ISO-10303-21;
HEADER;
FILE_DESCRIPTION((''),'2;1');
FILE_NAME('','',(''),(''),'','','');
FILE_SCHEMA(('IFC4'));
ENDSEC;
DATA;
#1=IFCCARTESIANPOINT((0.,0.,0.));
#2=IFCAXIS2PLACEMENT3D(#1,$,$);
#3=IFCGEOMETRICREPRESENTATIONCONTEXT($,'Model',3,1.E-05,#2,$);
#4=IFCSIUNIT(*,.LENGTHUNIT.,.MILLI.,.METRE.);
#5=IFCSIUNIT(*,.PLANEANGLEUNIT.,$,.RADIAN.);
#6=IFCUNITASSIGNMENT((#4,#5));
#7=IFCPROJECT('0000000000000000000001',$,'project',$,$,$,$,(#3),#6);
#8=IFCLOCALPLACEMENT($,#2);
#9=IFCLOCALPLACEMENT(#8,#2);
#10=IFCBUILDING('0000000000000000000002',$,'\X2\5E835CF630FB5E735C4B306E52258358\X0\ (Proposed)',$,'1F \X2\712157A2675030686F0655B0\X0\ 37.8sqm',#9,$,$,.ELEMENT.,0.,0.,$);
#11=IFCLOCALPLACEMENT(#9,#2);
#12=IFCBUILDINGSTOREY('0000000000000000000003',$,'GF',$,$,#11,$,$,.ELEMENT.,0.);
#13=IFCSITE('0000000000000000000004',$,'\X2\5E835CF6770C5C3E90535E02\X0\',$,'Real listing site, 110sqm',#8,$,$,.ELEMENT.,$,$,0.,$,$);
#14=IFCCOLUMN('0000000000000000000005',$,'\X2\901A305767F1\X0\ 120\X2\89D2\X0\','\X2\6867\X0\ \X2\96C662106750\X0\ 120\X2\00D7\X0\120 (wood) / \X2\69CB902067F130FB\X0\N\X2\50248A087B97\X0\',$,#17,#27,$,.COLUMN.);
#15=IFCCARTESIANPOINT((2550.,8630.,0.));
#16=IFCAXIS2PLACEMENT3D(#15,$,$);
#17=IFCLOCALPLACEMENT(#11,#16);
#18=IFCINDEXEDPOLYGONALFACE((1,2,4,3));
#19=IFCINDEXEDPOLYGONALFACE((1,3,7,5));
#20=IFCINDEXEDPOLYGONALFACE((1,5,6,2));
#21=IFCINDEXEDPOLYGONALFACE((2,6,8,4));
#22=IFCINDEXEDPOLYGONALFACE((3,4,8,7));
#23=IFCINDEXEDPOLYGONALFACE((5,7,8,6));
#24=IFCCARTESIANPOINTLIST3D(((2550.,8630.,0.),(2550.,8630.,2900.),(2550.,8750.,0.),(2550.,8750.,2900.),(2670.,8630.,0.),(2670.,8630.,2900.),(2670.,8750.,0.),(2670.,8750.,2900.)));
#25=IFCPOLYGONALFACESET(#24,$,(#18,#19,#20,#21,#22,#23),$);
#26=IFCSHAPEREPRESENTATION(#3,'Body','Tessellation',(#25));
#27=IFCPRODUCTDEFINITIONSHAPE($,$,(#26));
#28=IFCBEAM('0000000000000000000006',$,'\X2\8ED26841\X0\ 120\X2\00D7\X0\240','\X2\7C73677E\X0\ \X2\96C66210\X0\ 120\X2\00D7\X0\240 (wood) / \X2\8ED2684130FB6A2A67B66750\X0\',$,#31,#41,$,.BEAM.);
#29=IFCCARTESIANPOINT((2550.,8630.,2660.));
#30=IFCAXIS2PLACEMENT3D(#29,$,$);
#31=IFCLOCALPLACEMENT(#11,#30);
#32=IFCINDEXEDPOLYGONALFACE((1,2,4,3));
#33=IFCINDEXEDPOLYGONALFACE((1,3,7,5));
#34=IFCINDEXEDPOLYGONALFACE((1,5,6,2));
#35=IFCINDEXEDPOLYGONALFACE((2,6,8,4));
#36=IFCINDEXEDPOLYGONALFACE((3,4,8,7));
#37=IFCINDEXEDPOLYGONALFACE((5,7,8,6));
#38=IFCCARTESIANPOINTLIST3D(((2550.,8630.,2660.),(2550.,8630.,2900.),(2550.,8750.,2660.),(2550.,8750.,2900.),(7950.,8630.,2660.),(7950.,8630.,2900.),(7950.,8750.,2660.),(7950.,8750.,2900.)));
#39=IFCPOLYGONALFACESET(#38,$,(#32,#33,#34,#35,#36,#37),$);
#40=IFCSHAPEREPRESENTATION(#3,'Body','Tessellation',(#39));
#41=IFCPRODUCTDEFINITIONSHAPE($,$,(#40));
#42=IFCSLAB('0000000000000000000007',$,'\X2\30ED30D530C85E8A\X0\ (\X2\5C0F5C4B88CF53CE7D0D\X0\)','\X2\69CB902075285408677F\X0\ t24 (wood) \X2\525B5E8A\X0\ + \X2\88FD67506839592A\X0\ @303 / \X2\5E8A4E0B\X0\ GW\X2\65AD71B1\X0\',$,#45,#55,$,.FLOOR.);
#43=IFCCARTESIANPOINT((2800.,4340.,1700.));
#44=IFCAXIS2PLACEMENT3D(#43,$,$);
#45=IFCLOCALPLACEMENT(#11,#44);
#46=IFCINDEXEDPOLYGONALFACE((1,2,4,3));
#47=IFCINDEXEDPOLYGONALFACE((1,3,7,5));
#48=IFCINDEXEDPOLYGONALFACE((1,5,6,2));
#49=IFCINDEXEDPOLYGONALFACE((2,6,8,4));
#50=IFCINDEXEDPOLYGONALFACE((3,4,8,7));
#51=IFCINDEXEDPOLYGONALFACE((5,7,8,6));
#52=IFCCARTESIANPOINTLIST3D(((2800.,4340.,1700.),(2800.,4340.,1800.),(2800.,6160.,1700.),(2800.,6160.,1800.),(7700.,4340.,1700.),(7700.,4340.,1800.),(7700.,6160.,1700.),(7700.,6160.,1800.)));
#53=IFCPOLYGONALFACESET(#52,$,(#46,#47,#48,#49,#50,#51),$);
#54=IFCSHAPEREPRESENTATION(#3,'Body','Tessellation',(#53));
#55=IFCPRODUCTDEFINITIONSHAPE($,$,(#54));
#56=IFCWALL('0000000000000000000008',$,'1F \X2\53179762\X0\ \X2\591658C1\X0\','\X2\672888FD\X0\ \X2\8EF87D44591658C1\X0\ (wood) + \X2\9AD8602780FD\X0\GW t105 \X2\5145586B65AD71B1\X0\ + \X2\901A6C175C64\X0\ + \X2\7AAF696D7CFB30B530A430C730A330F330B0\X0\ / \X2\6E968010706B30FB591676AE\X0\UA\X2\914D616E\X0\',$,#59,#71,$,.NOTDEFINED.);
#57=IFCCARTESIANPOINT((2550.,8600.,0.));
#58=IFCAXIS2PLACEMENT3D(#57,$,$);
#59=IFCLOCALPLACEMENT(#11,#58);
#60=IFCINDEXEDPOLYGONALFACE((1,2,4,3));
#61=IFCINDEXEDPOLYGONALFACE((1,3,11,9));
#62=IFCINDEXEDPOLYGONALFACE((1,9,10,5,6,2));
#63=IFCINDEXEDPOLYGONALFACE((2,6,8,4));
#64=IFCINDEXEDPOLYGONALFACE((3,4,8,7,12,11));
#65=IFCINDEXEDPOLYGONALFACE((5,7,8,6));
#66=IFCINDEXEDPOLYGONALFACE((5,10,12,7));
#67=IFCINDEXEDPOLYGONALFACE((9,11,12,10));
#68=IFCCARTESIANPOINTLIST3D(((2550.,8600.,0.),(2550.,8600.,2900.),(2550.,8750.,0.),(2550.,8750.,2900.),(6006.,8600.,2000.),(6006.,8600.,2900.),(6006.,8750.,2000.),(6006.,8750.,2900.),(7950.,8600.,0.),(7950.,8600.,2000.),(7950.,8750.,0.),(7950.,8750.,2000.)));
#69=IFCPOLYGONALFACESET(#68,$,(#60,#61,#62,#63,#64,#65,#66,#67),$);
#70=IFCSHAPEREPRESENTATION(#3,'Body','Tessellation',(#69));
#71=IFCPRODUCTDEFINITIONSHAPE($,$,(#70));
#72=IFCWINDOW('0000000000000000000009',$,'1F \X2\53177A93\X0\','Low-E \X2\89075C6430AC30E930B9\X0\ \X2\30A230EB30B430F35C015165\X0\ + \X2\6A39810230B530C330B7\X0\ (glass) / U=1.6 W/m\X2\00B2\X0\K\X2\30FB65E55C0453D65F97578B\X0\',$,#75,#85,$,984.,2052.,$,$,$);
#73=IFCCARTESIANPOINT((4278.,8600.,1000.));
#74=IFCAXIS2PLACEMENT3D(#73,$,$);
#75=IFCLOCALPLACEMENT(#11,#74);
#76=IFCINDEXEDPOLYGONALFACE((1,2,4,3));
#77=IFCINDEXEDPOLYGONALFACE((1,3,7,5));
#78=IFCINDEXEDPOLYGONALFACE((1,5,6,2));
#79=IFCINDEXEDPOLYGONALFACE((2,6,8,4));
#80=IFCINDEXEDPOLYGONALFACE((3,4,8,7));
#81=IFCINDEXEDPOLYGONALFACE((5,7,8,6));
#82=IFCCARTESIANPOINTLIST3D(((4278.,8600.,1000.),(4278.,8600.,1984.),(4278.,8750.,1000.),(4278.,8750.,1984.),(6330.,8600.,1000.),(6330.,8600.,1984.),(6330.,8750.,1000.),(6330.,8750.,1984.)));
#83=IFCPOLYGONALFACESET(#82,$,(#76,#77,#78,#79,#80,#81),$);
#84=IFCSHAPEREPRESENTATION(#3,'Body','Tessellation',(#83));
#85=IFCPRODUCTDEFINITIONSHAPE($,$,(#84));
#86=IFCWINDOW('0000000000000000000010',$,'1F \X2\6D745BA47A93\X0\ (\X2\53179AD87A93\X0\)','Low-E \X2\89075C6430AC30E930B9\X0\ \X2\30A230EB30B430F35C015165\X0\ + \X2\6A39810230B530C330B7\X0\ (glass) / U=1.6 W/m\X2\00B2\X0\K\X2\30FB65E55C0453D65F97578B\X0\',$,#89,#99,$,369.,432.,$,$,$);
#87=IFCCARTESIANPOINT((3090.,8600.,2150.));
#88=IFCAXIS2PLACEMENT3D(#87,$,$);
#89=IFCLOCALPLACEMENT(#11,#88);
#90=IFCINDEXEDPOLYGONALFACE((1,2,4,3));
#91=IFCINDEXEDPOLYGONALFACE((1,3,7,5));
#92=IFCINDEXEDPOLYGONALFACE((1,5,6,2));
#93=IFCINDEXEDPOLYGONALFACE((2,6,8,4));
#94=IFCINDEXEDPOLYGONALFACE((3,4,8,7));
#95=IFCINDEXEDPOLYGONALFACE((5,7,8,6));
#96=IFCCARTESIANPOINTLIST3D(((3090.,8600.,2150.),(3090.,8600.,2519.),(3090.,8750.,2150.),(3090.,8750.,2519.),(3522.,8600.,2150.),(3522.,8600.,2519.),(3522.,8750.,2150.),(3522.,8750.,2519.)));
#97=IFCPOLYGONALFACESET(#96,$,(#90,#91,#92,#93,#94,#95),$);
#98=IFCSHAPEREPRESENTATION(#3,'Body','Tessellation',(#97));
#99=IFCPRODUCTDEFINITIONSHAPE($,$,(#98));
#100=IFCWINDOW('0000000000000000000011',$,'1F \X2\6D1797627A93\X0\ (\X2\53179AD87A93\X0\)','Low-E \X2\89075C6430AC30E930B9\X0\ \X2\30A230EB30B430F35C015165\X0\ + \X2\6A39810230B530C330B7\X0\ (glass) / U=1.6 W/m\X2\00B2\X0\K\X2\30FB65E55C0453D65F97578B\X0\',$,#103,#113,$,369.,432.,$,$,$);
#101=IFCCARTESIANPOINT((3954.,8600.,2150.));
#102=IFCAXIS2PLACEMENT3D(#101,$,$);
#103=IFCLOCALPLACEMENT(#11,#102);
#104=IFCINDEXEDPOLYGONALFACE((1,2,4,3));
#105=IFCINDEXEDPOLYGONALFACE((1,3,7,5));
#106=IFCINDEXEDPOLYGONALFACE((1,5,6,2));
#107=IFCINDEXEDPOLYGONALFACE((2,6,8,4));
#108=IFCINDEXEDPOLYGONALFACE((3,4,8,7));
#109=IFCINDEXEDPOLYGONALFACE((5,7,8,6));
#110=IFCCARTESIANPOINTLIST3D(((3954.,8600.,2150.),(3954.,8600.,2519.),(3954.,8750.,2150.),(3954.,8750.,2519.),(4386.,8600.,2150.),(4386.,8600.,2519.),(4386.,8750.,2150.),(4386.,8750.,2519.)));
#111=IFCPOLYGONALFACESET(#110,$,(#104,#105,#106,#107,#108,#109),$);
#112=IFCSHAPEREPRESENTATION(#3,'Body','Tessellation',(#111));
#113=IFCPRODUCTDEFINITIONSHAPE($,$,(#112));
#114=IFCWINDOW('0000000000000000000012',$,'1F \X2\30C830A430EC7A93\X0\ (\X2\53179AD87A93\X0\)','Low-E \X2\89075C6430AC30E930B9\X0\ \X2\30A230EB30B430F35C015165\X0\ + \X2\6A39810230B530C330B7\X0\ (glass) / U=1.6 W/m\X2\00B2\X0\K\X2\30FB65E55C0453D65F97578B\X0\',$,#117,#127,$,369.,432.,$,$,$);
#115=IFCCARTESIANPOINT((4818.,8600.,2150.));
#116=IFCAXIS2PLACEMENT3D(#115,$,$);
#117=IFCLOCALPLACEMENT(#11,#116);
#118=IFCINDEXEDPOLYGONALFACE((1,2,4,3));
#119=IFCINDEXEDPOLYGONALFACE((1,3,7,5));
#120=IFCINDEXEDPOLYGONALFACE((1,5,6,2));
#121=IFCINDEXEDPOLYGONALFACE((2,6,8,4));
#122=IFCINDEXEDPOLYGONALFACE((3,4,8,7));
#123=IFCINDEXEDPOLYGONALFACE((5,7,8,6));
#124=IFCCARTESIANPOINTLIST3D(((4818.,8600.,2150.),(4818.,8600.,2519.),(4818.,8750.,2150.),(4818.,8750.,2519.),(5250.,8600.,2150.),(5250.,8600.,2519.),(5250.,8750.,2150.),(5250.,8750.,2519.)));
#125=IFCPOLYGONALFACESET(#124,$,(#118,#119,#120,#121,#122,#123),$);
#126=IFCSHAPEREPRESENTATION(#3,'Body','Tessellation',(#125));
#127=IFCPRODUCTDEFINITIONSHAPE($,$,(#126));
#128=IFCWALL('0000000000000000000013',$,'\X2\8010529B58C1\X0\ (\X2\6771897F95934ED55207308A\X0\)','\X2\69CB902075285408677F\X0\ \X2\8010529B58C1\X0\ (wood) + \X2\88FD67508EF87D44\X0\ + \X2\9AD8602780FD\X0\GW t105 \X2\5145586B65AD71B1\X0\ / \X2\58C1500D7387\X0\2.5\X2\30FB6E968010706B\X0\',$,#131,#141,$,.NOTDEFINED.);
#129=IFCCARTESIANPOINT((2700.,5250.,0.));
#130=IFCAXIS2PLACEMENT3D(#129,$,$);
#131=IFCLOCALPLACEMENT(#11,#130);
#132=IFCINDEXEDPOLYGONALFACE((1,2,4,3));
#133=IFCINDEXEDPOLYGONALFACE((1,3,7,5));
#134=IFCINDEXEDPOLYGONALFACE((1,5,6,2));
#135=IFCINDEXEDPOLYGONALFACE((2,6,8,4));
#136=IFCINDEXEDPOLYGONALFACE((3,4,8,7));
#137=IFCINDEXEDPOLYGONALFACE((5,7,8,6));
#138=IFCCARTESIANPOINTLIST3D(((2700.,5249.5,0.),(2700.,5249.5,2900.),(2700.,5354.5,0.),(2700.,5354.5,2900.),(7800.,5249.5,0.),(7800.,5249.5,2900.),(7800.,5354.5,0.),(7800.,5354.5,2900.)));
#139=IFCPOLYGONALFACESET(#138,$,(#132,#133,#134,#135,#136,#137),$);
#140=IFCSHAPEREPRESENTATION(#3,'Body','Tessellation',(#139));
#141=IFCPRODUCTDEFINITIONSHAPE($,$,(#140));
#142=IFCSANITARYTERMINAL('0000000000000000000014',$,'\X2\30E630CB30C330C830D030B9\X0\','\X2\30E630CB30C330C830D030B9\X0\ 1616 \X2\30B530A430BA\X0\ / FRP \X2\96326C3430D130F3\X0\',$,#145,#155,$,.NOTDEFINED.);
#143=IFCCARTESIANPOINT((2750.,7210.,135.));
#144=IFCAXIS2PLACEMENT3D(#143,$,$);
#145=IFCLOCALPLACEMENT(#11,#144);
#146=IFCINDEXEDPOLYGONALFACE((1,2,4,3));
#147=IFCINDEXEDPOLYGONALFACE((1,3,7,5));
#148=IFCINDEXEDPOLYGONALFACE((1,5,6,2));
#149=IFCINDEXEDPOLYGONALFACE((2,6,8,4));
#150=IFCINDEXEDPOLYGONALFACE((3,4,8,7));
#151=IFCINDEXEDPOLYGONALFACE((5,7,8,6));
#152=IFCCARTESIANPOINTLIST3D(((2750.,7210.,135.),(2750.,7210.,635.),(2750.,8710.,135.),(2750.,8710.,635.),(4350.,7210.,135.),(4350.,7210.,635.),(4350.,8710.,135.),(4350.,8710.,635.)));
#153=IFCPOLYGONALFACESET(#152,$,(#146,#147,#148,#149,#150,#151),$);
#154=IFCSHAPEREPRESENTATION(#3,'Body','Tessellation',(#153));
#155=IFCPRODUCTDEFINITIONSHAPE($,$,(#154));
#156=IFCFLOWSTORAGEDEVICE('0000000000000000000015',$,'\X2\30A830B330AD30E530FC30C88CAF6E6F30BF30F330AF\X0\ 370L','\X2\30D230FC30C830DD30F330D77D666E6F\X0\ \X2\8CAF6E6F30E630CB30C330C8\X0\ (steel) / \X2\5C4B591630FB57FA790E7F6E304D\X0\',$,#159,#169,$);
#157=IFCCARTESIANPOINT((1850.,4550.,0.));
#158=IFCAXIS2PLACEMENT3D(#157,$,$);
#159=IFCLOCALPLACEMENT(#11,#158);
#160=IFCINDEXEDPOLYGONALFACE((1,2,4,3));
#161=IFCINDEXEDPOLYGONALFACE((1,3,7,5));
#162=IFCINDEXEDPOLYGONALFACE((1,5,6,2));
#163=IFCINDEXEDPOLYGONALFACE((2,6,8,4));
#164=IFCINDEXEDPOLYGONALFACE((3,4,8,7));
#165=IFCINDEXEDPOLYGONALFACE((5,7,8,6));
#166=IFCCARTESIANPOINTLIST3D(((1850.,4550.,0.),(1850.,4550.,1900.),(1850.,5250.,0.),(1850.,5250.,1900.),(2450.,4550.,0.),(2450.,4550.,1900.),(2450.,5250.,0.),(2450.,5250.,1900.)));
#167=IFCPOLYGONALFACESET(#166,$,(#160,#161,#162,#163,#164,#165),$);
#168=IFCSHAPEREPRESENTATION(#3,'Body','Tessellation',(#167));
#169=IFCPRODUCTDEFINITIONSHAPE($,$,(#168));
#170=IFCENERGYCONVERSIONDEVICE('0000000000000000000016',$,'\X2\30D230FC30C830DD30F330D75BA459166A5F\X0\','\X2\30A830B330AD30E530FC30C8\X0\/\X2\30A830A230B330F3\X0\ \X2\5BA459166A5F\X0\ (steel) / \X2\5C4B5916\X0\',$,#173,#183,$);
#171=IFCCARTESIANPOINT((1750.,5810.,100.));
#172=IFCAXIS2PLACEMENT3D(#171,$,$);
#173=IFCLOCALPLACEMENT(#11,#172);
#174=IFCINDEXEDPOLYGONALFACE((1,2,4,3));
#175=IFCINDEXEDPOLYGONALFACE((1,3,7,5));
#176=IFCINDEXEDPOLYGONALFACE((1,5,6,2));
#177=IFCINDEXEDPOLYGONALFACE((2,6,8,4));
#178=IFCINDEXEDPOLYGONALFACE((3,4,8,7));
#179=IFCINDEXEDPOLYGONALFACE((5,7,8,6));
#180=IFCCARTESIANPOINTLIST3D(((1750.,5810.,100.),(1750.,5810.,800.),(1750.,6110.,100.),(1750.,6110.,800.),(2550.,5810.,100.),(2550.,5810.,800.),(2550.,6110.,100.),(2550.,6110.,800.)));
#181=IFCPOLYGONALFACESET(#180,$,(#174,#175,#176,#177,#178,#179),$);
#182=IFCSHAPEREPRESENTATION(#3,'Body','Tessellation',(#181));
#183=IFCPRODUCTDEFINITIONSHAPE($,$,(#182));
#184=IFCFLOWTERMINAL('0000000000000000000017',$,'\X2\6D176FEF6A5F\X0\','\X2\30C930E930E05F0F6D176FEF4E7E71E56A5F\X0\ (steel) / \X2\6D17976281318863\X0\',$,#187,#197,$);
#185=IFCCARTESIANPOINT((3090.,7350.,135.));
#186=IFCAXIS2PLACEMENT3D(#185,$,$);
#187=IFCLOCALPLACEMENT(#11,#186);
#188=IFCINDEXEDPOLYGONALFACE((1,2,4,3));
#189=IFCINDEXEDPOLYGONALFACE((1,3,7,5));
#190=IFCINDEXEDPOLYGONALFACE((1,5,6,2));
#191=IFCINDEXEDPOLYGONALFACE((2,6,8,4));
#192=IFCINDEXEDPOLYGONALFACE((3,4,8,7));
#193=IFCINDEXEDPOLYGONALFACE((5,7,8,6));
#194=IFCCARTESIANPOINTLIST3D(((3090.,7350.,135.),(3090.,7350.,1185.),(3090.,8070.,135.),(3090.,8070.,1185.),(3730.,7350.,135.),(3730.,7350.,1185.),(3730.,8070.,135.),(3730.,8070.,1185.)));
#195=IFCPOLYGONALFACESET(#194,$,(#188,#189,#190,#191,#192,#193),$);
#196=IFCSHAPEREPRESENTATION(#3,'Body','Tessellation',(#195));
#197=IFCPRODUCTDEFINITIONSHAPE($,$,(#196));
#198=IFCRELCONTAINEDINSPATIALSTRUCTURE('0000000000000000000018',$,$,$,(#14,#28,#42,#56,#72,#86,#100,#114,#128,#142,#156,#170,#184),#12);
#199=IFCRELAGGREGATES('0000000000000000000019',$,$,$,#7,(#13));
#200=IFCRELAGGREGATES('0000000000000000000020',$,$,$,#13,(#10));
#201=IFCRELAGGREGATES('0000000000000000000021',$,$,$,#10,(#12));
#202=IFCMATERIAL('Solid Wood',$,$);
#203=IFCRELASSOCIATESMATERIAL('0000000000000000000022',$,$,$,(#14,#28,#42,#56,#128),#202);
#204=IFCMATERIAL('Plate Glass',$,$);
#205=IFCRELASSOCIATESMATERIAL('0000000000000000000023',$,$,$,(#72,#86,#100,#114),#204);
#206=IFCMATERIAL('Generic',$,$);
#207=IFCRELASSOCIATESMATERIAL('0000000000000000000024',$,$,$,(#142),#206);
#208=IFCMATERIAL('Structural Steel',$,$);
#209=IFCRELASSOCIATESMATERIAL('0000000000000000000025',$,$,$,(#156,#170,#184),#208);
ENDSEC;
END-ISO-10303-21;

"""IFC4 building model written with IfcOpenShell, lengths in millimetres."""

from ifc_helpers import new_model, si_unit, frame, frame_2d, origin, place, context, project, spatial, rectangle, extrude, material, element, fill, save


model = new_model("IFC4")

# Units and contexts
model_context = context("Model", 3, precision=1e-05, world=origin())
ifc_project = project(units=[si_unit("LENGTHUNIT", "METRE", prefix="MILLI"), si_unit("PLANEANGLEUNIT", "RADIAN")], contexts=[model_context])

# Site, building, storey
site_placement = place(None, origin())
site = spatial("IfcSite", under=ifc_project, at=site_placement, Name="広島県尾道市", ObjectType="Real listing site, 110sqm", CompositionType="ELEMENT", RefElevation=0.0)
building_placement = place(site_placement, origin())
building = spatial("IfcBuilding", under=site, at=building_placement, Name="広島・平屋の別荘 (Proposed)", ObjectType="1F 無垢材と漆喰 37.8sqm", CompositionType="ELEMENT", ElevationOfRefHeight=0.0, ElevationOfTerrain=0.0)
storey_placement = place(building_placement, origin())
storey = spatial("IfcBuildingStorey", under=building, at=storey_placement, Name="GF", CompositionType="ELEMENT", Elevation=0.0)

# Column
ifc_material_1 = material(Name="Solid Wood")
column_1_placement = place(storey_placement, frame((2550.0, 8630.0, 0.0)))
element("IfcColumn", 1, at=column_1_placement, inside=storey, material=ifc_material_1, Name="通し柱 120角", Description="桧 集成材 120×120 (wood) / 構造柱・N値計算", PredefinedType="COLUMN", context=model_context, shape_type="SweptSolid", body=[
    extrude(rectangle(XDim=120.0, YDim=120.0, at=frame_2d((60.0, 60.0))), frame((2550.0, 8630.0, 0.0)), (0.0, 0.0, 1.0), 2900.0),
])

# Beam
beam_1_placement = place(storey_placement, frame((2550.0, 8630.0, 2660.0)))
element("IfcBeam", 2, at=beam_1_placement, inside=storey, material=ifc_material_1, Name="軒桁 120×240", Description="米松 集成 120×240 (wood) / 軒桁・横架材", PredefinedType="BEAM", context=model_context, shape_type="SweptSolid", body=[
    extrude(rectangle(XDim=5400.0, YDim=120.0, at=frame_2d((2700.0, 60.0))), frame((2550.0, 8630.0, 2660.0)), (0.0, 0.0, 1.0), 240.0),
])

# Slab
slab_placement = place(storey_placement, frame((2800.0, 4340.0, 1700.0)))
element("IfcSlab", 3, at=slab_placement, inside=storey, material=ifc_material_1, Name="ロフト床 (小屋裏収納)", Description="構造用合板 t24 (wood) 剛床 + 製材根太 @303 / 床下 GW断熱", PredefinedType="FLOOR", context=model_context, shape_type="SweptSolid", body=[
    extrude(rectangle(XDim=4900.0, YDim=1820.0, at=frame_2d((2450.0, 910.0))), frame((2800.0, 4340.0, 1700.0)), (0.0, 0.0, 1.0), 100.0),
])

# Wall, openings, windows
wall_1_placement = place(storey_placement, frame((2550.0, 8600.0, 0.0)))
wall_1 = element("IfcWall", 4, at=wall_1_placement, inside=storey, material=ifc_material_1, Name="1F 北面 外壁", Description="木製 軸組外壁 (wood) + 高性能GW t105 充填断熱 + 通気層 + 窯業系サイディング / 準耐火・外皮UA配慮", PredefinedType="NOTDEFINED", context=model_context, shape_type="SweptSolid", body=[
    extrude(rectangle(XDim=5400.0, YDim=150.0, at=frame_2d((2700.0, 75.0))), frame((2550.0, 8600.0, 0.0)), (0.0, 0.0, 1.0), 2900.0),
])
opening_1_placement = place(storey_placement, frame((4278.0, 8600.0, 1000.0)))
opening_1 = element("IfcOpeningElement", 5, at=opening_1_placement, cuts=wall_1, PredefinedType="NOTDEFINED", context=model_context, shape_type="SweptSolid", body=[
    extrude(rectangle(XDim=2052.0, YDim=150.0, at=frame_2d((1026.0, 75.0))), frame((4278.0, 8600.0, 1000.0)), (0.0, 0.0, 1.0), 984.0),
])
opening_2_placement = place(storey_placement, frame((3090.0, 8600.0, 2150.0)))
opening_2 = element("IfcOpeningElement", 6, at=opening_2_placement, cuts=wall_1, PredefinedType="NOTDEFINED", context=model_context, shape_type="SweptSolid", body=[
    extrude(rectangle(XDim=432.0, YDim=150.0, at=frame_2d((216.0, 75.0))), frame((3090.0, 8600.0, 2150.0)), (0.0, 0.0, 1.0), 369.0),
])
opening_3_placement = place(storey_placement, frame((3954.0, 8600.0, 2150.0)))
opening_3 = element("IfcOpeningElement", 7, at=opening_3_placement, cuts=wall_1, PredefinedType="NOTDEFINED", context=model_context, shape_type="SweptSolid", body=[
    extrude(rectangle(XDim=432.0, YDim=150.0, at=frame_2d((216.0, 75.0))), frame((3954.0, 8600.0, 2150.0)), (0.0, 0.0, 1.0), 369.0),
])
opening_4_placement = place(storey_placement, frame((4818.0, 8600.0, 2150.0)))
opening_4 = element("IfcOpeningElement", 8, at=opening_4_placement, cuts=wall_1, PredefinedType="NOTDEFINED", context=model_context, shape_type="SweptSolid", body=[
    extrude(rectangle(XDim=432.0, YDim=150.0, at=frame_2d((216.0, 75.0))), frame((4818.0, 8600.0, 2150.0)), (0.0, 0.0, 1.0), 369.0),
])
ifc_material_2 = material(Name="Plate Glass")
window_1_placement = place(storey_placement, frame((4278.0, 8600.0, 1000.0)))
window_1 = element("IfcWindow", 9, at=window_1_placement, inside=storey, material=ifc_material_2, Name="1F 北窓", Description="Low-E 複層ガラス アルゴン封入 + 樹脂サッシ (glass) / U=1.6 W/m²K・日射取得型", OverallHeight=984.0, OverallWidth=2052.0, context=model_context, shape_type="SweptSolid", body=[
    extrude(rectangle(XDim=2052.0, YDim=150.0, at=frame_2d((1026.0, 75.0))), frame((4278.0, 8600.0, 1000.0)), (0.0, 0.0, 1.0), 984.0),
])
fill(opening_1, window_1)
window_2_placement = place(storey_placement, frame((3090.0, 8600.0, 2150.0)))
window_2 = element("IfcWindow", 10, at=window_2_placement, inside=storey, material=ifc_material_2, Name="1F 浴室窓 (北高窓)", Description="Low-E 複層ガラス アルゴン封入 + 樹脂サッシ (glass) / U=1.6 W/m²K・日射取得型", OverallHeight=369.0, OverallWidth=432.0, context=model_context, shape_type="SweptSolid", body=[
    extrude(rectangle(XDim=432.0, YDim=150.0, at=frame_2d((216.0, 75.0))), frame((3090.0, 8600.0, 2150.0)), (0.0, 0.0, 1.0), 369.0),
])
fill(opening_2, window_2)
window_3_placement = place(storey_placement, frame((3954.0, 8600.0, 2150.0)))
window_3 = element("IfcWindow", 11, at=window_3_placement, inside=storey, material=ifc_material_2, Name="1F 洗面窓 (北高窓)", Description="Low-E 複層ガラス アルゴン封入 + 樹脂サッシ (glass) / U=1.6 W/m²K・日射取得型", OverallHeight=369.0, OverallWidth=432.0, context=model_context, shape_type="SweptSolid", body=[
    extrude(rectangle(XDim=432.0, YDim=150.0, at=frame_2d((216.0, 75.0))), frame((3954.0, 8600.0, 2150.0)), (0.0, 0.0, 1.0), 369.0),
])
fill(opening_3, window_3)
window_4_placement = place(storey_placement, frame((4818.0, 8600.0, 2150.0)))
window_4 = element("IfcWindow", 12, at=window_4_placement, inside=storey, material=ifc_material_2, Name="1F トイレ窓 (北高窓)", Description="Low-E 複層ガラス アルゴン封入 + 樹脂サッシ (glass) / U=1.6 W/m²K・日射取得型", OverallHeight=369.0, OverallWidth=432.0, context=model_context, shape_type="SweptSolid", body=[
    extrude(rectangle(XDim=432.0, YDim=150.0, at=frame_2d((216.0, 75.0))), frame((4818.0, 8600.0, 2150.0)), (0.0, 0.0, 1.0), 369.0),
])
fill(opening_4, window_4)

# Wall
wall_2_placement = place(storey_placement, frame((2700.0, 5250.0, 0.0)))
element("IfcWall", 13, at=wall_2_placement, inside=storey, material=ifc_material_1, Name="耐力壁 (東西間仕切り)", Description="構造用合板 耐力壁 (wood) + 製材軸組 + 高性能GW t105 充填断熱 / 壁倍率2.5・準耐火", PredefinedType="NOTDEFINED", context=model_context, shape_type="SweptSolid", body=[
    extrude(rectangle(XDim=5100.0, YDim=105.0, at=frame_2d((2550.0, 52.0))), frame((2700.0, 5250.0, 0.0)), (0.0, 0.0, 1.0), 2900.0),
])

# Sanitary terminal
ifc_material_3 = material(Name="Generic")
sanitary_terminal_placement = place(storey_placement, frame((2750.0, 7210.0, 135.0)))
element("IfcSanitaryTerminal", 14, at=sanitary_terminal_placement, inside=storey, material=ifc_material_3, Name="ユニットバス", Description="ユニットバス 1616 サイズ / FRP 防水パン", PredefinedType="NOTDEFINED", context=model_context, shape_type="SweptSolid", body=[
    extrude(rectangle(XDim=1600.0, YDim=1500.0, at=frame_2d((800.0, 750.0))), frame((2750.0, 7210.0, 135.0)), (0.0, 0.0, 1.0), 500.0),
])

# Flow storage device
ifc_material_4 = material(Name="Structural Steel")
flow_storage_device_placement = place(storey_placement, frame((1850.0, 4550.0, 0.0)))
element("IfcFlowStorageDevice", 15, at=flow_storage_device_placement, inside=storey, material=ifc_material_4, Name="エコキュート貯湯タンク 370L", Description="ヒートポンプ給湯 貯湯ユニット (steel) / 屋外・基礎置き", context=model_context, shape_type="SweptSolid", body=[
    extrude(rectangle(XDim=600.0, YDim=700.0, at=frame_2d((300.0, 350.0))), frame((1850.0, 4550.0, 0.0)), (0.0, 0.0, 1.0), 1900.0),
])

# Energy conversion device
energy_conversion_device_placement = place(storey_placement, frame((1750.0, 5810.0, 100.0)))
element("IfcEnergyConversionDevice", 16, at=energy_conversion_device_placement, inside=storey, material=ifc_material_4, Name="ヒートポンプ室外機", Description="エコキュート/エアコン 室外機 (steel) / 屋外", context=model_context, shape_type="SweptSolid", body=[
    extrude(rectangle(XDim=800.0, YDim=300.0, at=frame_2d((400.0, 150.0))), frame((1750.0, 5810.0, 100.0)), (0.0, 0.0, 1.0), 700.0),
])

# Flow terminal
flow_terminal_placement = place(storey_placement, frame((3090.0, 7350.0, 135.0)))
element("IfcFlowTerminal", 17, at=flow_terminal_placement, inside=storey, material=ifc_material_4, Name="洗濯機", Description="ドラム式洗濯乾燥機 (steel) / 洗面脱衣", context=model_context, shape_type="SweptSolid", body=[
    extrude(rectangle(XDim=640.0, YDim=720.0, at=frame_2d((320.0, 360.0))), frame((3090.0, 7350.0, 135.0)), (0.0, 0.0, 1.0), 1050.0),
])

save(model, "model.ifc")
